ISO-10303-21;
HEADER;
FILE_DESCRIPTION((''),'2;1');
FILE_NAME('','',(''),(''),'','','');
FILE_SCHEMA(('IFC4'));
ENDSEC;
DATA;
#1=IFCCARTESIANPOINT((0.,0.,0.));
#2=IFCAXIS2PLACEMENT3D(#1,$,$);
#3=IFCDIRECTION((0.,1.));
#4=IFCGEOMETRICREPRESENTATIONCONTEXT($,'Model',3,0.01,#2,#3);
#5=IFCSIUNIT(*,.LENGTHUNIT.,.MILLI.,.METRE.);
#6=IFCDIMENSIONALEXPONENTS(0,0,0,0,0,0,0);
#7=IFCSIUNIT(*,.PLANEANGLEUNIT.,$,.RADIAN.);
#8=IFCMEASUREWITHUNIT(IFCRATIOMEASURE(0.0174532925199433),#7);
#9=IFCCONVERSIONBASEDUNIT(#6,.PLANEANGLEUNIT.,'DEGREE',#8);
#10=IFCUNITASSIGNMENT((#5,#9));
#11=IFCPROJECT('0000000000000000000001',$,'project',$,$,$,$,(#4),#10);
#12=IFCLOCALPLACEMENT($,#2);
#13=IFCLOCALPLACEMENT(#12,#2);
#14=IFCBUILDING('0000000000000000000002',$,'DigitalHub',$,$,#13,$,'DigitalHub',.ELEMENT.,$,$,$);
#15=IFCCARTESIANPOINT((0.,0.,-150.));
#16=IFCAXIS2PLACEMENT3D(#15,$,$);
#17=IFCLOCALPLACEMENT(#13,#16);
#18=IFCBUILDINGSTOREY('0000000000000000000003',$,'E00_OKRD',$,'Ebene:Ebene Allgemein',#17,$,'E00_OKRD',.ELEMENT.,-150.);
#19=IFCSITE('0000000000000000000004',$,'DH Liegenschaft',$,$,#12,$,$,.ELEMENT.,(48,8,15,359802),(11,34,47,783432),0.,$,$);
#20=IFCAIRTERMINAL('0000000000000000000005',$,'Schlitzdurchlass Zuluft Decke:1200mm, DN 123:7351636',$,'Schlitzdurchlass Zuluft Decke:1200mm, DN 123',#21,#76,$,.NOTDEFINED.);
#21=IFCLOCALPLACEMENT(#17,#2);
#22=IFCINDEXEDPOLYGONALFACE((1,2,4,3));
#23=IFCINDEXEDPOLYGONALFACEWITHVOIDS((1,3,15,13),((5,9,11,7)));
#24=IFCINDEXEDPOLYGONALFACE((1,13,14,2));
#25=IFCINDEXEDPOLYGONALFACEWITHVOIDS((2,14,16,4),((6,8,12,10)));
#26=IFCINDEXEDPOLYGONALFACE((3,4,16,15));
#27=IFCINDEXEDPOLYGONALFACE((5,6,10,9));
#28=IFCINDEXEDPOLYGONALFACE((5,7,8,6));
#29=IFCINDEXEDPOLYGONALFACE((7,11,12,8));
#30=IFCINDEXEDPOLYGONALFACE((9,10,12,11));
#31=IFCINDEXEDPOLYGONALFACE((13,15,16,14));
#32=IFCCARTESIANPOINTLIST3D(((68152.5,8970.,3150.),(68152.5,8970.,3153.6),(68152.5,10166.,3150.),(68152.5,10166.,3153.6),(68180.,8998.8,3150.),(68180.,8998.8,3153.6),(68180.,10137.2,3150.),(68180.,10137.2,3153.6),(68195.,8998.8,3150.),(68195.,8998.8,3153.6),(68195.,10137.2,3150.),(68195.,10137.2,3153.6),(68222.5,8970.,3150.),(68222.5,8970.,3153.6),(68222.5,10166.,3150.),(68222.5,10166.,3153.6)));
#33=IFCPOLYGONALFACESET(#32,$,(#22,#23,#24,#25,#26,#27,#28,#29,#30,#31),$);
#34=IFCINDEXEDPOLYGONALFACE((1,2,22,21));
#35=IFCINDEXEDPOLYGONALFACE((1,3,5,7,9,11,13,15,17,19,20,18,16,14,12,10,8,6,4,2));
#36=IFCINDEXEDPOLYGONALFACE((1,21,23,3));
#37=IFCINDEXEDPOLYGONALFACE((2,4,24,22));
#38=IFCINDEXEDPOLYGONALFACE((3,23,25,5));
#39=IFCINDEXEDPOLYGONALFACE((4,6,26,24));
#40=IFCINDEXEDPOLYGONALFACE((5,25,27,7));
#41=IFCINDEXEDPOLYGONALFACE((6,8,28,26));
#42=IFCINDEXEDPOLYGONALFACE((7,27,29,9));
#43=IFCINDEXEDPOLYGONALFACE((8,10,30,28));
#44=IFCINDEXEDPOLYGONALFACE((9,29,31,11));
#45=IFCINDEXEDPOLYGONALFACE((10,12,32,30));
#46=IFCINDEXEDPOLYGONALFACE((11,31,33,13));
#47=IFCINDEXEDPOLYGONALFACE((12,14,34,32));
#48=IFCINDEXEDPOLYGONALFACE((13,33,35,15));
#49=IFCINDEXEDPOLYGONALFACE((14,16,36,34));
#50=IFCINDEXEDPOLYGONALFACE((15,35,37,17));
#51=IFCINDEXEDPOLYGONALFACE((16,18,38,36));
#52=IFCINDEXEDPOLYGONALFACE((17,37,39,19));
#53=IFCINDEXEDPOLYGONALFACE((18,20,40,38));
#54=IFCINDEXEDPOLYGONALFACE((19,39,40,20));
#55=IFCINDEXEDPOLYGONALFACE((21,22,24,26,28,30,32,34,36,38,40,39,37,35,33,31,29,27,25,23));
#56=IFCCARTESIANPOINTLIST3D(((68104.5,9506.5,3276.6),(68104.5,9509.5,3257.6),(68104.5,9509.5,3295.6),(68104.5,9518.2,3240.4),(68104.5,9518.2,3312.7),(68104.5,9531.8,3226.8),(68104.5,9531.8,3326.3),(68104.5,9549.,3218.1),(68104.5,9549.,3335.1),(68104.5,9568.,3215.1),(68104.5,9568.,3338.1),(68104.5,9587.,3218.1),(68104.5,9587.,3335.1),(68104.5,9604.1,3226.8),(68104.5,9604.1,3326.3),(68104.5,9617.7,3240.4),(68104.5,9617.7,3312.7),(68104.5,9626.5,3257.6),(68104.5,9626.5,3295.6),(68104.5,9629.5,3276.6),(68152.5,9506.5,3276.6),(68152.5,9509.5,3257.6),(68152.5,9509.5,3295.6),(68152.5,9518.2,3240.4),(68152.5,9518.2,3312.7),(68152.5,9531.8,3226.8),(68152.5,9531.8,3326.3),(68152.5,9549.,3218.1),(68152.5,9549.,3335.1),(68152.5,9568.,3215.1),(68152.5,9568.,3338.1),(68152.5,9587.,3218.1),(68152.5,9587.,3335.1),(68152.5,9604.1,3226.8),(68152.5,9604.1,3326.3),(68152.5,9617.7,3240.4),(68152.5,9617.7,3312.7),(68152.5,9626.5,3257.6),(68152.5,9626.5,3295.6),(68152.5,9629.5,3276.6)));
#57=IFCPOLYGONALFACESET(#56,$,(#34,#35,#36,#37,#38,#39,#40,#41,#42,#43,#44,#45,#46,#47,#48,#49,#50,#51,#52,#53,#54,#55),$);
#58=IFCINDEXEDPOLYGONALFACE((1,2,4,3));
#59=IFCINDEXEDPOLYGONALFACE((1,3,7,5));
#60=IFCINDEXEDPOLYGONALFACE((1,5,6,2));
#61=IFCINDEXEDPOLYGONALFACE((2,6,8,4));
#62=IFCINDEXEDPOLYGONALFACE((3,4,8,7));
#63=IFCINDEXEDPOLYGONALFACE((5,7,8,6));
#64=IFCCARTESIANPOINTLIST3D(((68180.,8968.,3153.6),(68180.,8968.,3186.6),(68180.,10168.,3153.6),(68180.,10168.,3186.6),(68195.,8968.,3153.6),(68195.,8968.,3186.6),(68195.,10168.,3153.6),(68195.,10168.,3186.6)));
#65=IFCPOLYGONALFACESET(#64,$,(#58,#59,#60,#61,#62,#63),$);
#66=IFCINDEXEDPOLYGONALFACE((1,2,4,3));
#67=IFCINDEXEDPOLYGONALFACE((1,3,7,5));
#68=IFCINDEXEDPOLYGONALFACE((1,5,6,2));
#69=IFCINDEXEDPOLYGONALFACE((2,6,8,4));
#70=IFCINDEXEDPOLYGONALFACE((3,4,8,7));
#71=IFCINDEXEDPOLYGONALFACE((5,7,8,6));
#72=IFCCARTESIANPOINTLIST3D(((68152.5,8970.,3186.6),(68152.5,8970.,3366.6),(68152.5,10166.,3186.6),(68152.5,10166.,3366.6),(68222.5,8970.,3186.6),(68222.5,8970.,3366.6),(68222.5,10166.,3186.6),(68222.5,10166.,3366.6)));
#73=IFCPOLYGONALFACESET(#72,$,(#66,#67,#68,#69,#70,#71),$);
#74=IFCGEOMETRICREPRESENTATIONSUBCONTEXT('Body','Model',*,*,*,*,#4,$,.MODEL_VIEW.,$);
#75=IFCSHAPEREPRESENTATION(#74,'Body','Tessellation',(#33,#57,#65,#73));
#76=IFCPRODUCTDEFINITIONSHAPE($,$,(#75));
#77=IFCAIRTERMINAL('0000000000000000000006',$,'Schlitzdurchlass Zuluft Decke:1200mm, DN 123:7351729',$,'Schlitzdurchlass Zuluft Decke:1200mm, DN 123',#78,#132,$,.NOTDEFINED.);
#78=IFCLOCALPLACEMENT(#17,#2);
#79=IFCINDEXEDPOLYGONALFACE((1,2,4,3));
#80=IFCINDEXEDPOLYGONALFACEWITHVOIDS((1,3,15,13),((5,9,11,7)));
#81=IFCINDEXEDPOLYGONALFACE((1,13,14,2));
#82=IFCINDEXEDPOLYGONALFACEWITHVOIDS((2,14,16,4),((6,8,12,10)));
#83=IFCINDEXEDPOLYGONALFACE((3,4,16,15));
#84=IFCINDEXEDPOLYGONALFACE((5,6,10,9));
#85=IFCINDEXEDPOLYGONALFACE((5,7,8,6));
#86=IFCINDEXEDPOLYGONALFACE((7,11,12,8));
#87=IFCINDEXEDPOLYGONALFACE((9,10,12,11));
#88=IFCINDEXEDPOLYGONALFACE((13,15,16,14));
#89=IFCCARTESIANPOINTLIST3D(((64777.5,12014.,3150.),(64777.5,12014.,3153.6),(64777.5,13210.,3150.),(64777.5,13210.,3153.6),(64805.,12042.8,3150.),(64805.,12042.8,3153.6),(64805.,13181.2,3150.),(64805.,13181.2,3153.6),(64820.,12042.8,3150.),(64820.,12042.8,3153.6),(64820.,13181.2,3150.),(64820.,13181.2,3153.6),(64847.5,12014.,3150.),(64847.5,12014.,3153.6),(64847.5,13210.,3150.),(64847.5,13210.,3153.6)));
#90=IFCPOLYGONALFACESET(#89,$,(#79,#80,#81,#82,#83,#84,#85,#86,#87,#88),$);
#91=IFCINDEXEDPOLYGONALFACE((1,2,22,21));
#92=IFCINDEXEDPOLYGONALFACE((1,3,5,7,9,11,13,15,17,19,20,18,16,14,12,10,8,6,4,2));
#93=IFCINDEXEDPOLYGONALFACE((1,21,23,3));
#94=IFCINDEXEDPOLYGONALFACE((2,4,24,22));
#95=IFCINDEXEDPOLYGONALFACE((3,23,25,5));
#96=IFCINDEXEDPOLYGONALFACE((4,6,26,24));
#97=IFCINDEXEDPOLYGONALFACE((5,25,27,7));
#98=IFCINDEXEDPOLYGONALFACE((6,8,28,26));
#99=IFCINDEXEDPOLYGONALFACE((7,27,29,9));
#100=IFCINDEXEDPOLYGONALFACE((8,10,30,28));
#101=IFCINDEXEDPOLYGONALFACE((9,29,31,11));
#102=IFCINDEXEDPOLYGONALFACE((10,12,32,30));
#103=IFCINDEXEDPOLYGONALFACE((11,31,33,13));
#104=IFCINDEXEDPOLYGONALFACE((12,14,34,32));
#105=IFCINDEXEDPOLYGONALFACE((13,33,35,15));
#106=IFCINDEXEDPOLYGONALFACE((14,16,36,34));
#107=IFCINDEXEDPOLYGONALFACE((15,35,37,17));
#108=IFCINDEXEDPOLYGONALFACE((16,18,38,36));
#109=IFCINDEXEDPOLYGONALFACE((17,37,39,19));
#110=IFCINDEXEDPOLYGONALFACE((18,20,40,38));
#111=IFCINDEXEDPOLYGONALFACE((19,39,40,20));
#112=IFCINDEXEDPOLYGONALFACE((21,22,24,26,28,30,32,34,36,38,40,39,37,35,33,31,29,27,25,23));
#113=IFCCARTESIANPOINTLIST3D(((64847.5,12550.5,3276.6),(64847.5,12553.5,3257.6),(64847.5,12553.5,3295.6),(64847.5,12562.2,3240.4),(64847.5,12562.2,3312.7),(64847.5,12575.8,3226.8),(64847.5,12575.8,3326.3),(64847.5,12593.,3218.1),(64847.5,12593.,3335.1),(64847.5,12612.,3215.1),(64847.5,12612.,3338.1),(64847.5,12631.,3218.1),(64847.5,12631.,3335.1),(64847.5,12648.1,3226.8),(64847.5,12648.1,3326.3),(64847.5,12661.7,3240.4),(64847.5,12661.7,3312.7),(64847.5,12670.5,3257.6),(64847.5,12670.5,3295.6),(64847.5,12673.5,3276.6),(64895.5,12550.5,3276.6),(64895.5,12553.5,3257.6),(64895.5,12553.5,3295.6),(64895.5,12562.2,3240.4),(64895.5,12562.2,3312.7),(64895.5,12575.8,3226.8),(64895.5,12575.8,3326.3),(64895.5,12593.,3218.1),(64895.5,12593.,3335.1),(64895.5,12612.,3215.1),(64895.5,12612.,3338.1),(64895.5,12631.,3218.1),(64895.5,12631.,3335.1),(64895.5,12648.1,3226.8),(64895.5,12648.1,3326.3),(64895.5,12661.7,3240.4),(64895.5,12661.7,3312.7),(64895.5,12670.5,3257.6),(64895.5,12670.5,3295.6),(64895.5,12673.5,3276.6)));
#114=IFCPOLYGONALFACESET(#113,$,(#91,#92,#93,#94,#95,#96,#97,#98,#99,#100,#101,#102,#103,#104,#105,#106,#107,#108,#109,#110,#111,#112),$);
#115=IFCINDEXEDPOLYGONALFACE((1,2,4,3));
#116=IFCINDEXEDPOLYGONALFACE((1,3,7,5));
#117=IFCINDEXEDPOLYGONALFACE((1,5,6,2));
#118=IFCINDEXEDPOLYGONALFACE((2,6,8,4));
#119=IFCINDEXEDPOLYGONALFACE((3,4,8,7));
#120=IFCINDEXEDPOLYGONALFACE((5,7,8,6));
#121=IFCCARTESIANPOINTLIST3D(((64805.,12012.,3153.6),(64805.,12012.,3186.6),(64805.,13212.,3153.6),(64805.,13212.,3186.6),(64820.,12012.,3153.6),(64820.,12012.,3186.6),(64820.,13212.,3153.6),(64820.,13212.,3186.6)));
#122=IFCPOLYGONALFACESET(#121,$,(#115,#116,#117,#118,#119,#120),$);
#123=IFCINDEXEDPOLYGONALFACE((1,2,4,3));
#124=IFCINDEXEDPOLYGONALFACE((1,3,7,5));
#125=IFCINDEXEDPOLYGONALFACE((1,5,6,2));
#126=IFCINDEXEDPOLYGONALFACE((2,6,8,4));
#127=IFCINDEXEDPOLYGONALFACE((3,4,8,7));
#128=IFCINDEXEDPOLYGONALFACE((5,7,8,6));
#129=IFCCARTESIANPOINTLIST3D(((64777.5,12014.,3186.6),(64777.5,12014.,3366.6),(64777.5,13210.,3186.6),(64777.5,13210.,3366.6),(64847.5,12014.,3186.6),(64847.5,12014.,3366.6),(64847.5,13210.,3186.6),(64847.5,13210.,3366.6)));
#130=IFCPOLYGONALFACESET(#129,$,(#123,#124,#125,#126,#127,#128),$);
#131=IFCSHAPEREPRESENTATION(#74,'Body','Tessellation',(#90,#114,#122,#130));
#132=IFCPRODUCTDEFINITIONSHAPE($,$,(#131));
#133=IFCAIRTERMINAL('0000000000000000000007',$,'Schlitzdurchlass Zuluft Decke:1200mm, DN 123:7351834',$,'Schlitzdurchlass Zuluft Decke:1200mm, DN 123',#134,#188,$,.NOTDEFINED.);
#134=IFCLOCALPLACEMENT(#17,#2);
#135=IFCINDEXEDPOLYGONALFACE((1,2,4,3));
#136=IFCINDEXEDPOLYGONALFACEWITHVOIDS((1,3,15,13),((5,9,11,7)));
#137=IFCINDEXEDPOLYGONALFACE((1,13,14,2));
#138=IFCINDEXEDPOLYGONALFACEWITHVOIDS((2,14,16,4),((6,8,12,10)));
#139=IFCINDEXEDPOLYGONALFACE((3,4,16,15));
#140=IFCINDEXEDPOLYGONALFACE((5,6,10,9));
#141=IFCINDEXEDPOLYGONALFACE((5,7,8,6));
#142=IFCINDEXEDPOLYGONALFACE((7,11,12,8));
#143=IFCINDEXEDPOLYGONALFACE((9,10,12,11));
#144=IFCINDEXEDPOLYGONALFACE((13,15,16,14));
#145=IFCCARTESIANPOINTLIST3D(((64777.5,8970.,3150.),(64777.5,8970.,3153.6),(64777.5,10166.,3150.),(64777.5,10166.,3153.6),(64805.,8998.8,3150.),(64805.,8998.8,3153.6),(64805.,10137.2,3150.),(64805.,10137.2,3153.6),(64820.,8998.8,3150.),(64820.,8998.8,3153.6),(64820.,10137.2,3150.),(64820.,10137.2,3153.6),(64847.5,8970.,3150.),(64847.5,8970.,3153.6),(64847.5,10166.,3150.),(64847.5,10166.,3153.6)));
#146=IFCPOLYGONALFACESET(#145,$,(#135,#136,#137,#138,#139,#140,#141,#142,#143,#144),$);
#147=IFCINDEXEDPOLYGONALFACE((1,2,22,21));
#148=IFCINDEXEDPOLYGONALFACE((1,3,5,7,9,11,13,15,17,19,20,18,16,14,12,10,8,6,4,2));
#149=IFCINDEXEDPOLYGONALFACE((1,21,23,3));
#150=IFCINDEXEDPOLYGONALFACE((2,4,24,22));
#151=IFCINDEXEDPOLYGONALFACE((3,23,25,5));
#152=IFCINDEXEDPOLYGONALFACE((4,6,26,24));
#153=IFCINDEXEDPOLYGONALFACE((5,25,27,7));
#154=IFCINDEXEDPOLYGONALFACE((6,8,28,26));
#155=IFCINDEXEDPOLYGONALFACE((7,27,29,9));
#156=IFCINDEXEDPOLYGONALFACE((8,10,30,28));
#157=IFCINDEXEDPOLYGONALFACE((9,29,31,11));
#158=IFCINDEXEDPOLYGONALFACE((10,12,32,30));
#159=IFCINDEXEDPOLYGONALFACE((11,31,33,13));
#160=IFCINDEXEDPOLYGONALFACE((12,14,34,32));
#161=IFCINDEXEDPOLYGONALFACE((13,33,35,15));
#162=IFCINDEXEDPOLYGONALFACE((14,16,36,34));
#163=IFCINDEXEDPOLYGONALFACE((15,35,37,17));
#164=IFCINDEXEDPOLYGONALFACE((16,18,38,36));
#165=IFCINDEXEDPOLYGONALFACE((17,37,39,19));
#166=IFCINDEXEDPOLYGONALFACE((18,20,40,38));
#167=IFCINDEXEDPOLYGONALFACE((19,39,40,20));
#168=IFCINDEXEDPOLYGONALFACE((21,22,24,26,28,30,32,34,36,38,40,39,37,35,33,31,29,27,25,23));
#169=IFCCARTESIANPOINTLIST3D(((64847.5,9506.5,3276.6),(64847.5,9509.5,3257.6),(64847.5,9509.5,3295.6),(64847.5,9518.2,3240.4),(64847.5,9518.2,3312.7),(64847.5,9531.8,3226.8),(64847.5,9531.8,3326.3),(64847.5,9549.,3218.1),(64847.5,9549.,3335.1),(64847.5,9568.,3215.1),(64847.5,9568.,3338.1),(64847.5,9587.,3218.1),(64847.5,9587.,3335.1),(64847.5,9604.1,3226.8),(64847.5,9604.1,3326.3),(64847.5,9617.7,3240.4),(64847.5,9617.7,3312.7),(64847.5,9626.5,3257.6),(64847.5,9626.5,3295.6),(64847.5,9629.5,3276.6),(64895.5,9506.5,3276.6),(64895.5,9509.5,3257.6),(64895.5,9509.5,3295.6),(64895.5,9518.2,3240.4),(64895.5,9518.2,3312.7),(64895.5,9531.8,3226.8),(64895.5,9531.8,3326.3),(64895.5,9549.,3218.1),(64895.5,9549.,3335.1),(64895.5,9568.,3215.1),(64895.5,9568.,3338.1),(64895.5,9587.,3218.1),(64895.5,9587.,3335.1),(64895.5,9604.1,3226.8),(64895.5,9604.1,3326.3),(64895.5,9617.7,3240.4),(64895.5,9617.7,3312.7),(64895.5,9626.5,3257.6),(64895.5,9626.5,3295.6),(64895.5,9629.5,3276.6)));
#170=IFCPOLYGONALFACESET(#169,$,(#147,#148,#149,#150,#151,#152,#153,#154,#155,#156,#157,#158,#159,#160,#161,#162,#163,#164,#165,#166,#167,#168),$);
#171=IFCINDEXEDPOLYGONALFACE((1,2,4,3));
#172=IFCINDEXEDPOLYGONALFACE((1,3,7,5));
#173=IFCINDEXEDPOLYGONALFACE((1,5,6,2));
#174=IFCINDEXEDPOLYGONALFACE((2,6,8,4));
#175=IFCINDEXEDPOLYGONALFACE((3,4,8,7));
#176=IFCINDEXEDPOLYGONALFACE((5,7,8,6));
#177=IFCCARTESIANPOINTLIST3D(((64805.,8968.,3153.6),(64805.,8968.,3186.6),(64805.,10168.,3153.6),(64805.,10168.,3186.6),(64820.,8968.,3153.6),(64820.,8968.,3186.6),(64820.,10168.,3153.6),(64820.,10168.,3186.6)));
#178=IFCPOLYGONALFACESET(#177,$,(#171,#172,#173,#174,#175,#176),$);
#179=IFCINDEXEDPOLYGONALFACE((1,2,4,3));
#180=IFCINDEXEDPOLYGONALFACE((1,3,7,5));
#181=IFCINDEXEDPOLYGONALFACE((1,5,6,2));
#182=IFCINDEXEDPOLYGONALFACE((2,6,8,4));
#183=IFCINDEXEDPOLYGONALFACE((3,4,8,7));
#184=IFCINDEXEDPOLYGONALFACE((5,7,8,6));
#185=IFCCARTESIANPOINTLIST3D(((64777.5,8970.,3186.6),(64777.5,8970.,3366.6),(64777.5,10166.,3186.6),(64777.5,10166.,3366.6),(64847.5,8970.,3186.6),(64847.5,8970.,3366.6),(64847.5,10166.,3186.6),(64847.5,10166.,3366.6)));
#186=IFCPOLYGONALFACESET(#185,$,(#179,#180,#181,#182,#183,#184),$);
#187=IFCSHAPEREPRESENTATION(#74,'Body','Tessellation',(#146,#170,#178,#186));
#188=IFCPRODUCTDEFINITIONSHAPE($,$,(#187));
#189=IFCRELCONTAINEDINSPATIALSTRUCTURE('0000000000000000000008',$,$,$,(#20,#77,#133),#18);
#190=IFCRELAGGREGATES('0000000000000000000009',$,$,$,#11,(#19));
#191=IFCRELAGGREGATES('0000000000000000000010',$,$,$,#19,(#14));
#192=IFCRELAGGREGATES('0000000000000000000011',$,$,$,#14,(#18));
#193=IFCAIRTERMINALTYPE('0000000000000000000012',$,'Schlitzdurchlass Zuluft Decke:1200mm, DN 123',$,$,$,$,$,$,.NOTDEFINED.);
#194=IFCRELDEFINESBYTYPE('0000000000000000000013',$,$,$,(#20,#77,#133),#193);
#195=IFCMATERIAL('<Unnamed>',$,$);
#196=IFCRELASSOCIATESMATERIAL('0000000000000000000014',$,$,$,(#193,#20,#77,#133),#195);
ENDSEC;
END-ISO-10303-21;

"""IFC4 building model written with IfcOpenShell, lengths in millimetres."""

from ifc_helpers import new_model, entity, si_unit, converted_unit, direction, frame, origin, place, context, subcontext, project, spatial, indexed_curve, outline, extrude, source, transform, mapped, material, type_object, type_shapes, element, save


model = new_model("IFC4")

# Units and contexts
model_context = context("Model", 3, precision=0.01, world=origin(), true_north=direction((0.0, 1.0)))
body_context = subcontext(model_context, "Body", "Model", "MODEL_VIEW")
ifc_project = project(units=[si_unit("LENGTHUNIT", "METRE", prefix="MILLI"), converted_unit("PLANEANGLEUNIT", "DEGREE", entity("IfcRatioMeasure", 0.0174532925199433), si_unit("PLANEANGLEUNIT", "RADIAN"), dimensions=[0, 0, 0, 0, 0, 0, 0])], contexts=[model_context])

# Site, building, storey
site_placement = place(None, origin())
site = spatial("IfcSite", under=ifc_project, at=site_placement, Name="DH Liegenschaft", CompositionType="ELEMENT", RefLatitude=(48, 8, 15, 359802), RefLongitude=(11, 34, 47, 783432), RefElevation=0.0)
building_placement = place(site_placement, origin())
building = spatial("IfcBuilding", under=site, at=building_placement, Name="DigitalHub", LongName="DigitalHub", CompositionType="ELEMENT")
storey_placement = place(building_placement, frame((0.0, 0.0, -150.0)))
storey = spatial("IfcBuildingStorey", under=building, at=storey_placement, Name="E00_OKRD", ObjectType="Ebene:Ebene Allgemein", LongName="E00_OKRD", CompositionType="ELEMENT", Elevation=-150.0)

# Air terminals
ifc_material_1 = material(Name="<Unnamed>")
air_terminal_type = type_object("IfcAirTerminalType", Name="Schlitzdurchlass Zuluft Decke:1200mm, DN 123", PredefinedType="NOTDEFINED", material=ifc_material_1)
shared_shape_1 = source(origin(), body_context, "Body", "SweptSolid", [
    extrude(outline(indexed_curve([(-598.0, -35.0), (598.0, -35.0), (598.0, 35.0), (-598.0, 35.0), (-598.0, -35.0)], self_intersect=False), holes=[indexed_curve([(-569.2, -7.5), (-569.2, 7.5), (569.2, 7.5), (569.2, -7.5), (-569.2, -7.5)], self_intersect=False)]), frame((600.0, 35.0, 0.0), z_axis=(0.0, 0.0, 1.0), x_axis=(-1.0, 0.0, 0.0)), (0.0, 0.0, 1.0), 3.6),
    extrude(outline(indexed_curve([(61.5, 0.0), (58.5, 19.0), (49.8, 36.1), (36.1, 49.8), (19.0, 58.5), (0.0, 61.5), (-19.0, 58.5), (-36.1, 49.8), (-49.8, 36.1), (-58.5, 19.0), (-61.5, 0.0), (-58.5, -19.0), (-49.8, -36.1), (-36.1, -49.8), (-19.0, -58.5), (0.0, -61.5), (19.0, -58.5), (36.1, -49.8), (49.8, -36.1), (58.5, -19.0), (61.5, 0.0)], self_intersect=False)), frame((600.0, 70.0, 126.6), z_axis=(0.0, 1.0, 0.0), x_axis=(-1.0, 0.0, 0.0)), (0.0, 0.0, 1.0), 48.0),
    extrude(outline(indexed_curve([(-600.0, -7.5), (600.0, -7.5), (600.0, 7.5), (-600.0, 7.5), (-600.0, -7.5)], self_intersect=False)), frame((600.0, 35.0, 3.6), z_axis=(0.0, 0.0, 1.0), x_axis=(-1.0, 0.0, 0.0)), (0.0, 0.0, 1.0), 33.0),
    extrude(outline(indexed_curve([(-598.0, -35.0), (598.0, -35.0), (598.0, 35.0), (-598.0, 35.0), (-598.0, -35.0)], self_intersect=False)), frame((600.0, 35.0, 36.6), z_axis=(0.0, 0.0, 1.0), x_axis=(-1.0, 0.0, 0.0)), (0.0, 0.0, 1.0), 180.0),
])
type_shapes(air_terminal_type, [shared_shape_1])
for number, where, z_axis, x_axis, name in (
    (1, (68222.5, 8968.0, 3150.0), (0.0, 0.0, 1.0), (0.0, 1.0, 0.0), "Schlitzdurchlass Zuluft Decke:1200mm, DN 123:7351636"),
    (2, (64777.5, 13212.0, 3150.0), (0.0, 0.0, 1.0), (0.0, -1.0, 0.0), "Schlitzdurchlass Zuluft Decke:1200mm, DN 123:7351729"),
    (3, (64777.5, 10168.0, 3150.0), (0.0, 0.0, 1.0), (0.0, -1.0, 0.0), "Schlitzdurchlass Zuluft Decke:1200mm, DN 123:7351834"),
):
    element("IfcAirTerminal", number, at=place(storey_placement, frame(where, z_axis=z_axis, x_axis=x_axis)), inside=storey, type_object=air_terminal_type, material=ifc_material_1, Name=name, ObjectType="Schlitzdurchlass Zuluft Decke:1200mm, DN 123", PredefinedType="NOTDEFINED", context=body_context, shape_type="MappedRepresentation", body=[
        mapped(shared_shape_1, transform((0.0, 0.0, 0.0), scale=1.0)),
    ])

save(model, "model.ifc")
